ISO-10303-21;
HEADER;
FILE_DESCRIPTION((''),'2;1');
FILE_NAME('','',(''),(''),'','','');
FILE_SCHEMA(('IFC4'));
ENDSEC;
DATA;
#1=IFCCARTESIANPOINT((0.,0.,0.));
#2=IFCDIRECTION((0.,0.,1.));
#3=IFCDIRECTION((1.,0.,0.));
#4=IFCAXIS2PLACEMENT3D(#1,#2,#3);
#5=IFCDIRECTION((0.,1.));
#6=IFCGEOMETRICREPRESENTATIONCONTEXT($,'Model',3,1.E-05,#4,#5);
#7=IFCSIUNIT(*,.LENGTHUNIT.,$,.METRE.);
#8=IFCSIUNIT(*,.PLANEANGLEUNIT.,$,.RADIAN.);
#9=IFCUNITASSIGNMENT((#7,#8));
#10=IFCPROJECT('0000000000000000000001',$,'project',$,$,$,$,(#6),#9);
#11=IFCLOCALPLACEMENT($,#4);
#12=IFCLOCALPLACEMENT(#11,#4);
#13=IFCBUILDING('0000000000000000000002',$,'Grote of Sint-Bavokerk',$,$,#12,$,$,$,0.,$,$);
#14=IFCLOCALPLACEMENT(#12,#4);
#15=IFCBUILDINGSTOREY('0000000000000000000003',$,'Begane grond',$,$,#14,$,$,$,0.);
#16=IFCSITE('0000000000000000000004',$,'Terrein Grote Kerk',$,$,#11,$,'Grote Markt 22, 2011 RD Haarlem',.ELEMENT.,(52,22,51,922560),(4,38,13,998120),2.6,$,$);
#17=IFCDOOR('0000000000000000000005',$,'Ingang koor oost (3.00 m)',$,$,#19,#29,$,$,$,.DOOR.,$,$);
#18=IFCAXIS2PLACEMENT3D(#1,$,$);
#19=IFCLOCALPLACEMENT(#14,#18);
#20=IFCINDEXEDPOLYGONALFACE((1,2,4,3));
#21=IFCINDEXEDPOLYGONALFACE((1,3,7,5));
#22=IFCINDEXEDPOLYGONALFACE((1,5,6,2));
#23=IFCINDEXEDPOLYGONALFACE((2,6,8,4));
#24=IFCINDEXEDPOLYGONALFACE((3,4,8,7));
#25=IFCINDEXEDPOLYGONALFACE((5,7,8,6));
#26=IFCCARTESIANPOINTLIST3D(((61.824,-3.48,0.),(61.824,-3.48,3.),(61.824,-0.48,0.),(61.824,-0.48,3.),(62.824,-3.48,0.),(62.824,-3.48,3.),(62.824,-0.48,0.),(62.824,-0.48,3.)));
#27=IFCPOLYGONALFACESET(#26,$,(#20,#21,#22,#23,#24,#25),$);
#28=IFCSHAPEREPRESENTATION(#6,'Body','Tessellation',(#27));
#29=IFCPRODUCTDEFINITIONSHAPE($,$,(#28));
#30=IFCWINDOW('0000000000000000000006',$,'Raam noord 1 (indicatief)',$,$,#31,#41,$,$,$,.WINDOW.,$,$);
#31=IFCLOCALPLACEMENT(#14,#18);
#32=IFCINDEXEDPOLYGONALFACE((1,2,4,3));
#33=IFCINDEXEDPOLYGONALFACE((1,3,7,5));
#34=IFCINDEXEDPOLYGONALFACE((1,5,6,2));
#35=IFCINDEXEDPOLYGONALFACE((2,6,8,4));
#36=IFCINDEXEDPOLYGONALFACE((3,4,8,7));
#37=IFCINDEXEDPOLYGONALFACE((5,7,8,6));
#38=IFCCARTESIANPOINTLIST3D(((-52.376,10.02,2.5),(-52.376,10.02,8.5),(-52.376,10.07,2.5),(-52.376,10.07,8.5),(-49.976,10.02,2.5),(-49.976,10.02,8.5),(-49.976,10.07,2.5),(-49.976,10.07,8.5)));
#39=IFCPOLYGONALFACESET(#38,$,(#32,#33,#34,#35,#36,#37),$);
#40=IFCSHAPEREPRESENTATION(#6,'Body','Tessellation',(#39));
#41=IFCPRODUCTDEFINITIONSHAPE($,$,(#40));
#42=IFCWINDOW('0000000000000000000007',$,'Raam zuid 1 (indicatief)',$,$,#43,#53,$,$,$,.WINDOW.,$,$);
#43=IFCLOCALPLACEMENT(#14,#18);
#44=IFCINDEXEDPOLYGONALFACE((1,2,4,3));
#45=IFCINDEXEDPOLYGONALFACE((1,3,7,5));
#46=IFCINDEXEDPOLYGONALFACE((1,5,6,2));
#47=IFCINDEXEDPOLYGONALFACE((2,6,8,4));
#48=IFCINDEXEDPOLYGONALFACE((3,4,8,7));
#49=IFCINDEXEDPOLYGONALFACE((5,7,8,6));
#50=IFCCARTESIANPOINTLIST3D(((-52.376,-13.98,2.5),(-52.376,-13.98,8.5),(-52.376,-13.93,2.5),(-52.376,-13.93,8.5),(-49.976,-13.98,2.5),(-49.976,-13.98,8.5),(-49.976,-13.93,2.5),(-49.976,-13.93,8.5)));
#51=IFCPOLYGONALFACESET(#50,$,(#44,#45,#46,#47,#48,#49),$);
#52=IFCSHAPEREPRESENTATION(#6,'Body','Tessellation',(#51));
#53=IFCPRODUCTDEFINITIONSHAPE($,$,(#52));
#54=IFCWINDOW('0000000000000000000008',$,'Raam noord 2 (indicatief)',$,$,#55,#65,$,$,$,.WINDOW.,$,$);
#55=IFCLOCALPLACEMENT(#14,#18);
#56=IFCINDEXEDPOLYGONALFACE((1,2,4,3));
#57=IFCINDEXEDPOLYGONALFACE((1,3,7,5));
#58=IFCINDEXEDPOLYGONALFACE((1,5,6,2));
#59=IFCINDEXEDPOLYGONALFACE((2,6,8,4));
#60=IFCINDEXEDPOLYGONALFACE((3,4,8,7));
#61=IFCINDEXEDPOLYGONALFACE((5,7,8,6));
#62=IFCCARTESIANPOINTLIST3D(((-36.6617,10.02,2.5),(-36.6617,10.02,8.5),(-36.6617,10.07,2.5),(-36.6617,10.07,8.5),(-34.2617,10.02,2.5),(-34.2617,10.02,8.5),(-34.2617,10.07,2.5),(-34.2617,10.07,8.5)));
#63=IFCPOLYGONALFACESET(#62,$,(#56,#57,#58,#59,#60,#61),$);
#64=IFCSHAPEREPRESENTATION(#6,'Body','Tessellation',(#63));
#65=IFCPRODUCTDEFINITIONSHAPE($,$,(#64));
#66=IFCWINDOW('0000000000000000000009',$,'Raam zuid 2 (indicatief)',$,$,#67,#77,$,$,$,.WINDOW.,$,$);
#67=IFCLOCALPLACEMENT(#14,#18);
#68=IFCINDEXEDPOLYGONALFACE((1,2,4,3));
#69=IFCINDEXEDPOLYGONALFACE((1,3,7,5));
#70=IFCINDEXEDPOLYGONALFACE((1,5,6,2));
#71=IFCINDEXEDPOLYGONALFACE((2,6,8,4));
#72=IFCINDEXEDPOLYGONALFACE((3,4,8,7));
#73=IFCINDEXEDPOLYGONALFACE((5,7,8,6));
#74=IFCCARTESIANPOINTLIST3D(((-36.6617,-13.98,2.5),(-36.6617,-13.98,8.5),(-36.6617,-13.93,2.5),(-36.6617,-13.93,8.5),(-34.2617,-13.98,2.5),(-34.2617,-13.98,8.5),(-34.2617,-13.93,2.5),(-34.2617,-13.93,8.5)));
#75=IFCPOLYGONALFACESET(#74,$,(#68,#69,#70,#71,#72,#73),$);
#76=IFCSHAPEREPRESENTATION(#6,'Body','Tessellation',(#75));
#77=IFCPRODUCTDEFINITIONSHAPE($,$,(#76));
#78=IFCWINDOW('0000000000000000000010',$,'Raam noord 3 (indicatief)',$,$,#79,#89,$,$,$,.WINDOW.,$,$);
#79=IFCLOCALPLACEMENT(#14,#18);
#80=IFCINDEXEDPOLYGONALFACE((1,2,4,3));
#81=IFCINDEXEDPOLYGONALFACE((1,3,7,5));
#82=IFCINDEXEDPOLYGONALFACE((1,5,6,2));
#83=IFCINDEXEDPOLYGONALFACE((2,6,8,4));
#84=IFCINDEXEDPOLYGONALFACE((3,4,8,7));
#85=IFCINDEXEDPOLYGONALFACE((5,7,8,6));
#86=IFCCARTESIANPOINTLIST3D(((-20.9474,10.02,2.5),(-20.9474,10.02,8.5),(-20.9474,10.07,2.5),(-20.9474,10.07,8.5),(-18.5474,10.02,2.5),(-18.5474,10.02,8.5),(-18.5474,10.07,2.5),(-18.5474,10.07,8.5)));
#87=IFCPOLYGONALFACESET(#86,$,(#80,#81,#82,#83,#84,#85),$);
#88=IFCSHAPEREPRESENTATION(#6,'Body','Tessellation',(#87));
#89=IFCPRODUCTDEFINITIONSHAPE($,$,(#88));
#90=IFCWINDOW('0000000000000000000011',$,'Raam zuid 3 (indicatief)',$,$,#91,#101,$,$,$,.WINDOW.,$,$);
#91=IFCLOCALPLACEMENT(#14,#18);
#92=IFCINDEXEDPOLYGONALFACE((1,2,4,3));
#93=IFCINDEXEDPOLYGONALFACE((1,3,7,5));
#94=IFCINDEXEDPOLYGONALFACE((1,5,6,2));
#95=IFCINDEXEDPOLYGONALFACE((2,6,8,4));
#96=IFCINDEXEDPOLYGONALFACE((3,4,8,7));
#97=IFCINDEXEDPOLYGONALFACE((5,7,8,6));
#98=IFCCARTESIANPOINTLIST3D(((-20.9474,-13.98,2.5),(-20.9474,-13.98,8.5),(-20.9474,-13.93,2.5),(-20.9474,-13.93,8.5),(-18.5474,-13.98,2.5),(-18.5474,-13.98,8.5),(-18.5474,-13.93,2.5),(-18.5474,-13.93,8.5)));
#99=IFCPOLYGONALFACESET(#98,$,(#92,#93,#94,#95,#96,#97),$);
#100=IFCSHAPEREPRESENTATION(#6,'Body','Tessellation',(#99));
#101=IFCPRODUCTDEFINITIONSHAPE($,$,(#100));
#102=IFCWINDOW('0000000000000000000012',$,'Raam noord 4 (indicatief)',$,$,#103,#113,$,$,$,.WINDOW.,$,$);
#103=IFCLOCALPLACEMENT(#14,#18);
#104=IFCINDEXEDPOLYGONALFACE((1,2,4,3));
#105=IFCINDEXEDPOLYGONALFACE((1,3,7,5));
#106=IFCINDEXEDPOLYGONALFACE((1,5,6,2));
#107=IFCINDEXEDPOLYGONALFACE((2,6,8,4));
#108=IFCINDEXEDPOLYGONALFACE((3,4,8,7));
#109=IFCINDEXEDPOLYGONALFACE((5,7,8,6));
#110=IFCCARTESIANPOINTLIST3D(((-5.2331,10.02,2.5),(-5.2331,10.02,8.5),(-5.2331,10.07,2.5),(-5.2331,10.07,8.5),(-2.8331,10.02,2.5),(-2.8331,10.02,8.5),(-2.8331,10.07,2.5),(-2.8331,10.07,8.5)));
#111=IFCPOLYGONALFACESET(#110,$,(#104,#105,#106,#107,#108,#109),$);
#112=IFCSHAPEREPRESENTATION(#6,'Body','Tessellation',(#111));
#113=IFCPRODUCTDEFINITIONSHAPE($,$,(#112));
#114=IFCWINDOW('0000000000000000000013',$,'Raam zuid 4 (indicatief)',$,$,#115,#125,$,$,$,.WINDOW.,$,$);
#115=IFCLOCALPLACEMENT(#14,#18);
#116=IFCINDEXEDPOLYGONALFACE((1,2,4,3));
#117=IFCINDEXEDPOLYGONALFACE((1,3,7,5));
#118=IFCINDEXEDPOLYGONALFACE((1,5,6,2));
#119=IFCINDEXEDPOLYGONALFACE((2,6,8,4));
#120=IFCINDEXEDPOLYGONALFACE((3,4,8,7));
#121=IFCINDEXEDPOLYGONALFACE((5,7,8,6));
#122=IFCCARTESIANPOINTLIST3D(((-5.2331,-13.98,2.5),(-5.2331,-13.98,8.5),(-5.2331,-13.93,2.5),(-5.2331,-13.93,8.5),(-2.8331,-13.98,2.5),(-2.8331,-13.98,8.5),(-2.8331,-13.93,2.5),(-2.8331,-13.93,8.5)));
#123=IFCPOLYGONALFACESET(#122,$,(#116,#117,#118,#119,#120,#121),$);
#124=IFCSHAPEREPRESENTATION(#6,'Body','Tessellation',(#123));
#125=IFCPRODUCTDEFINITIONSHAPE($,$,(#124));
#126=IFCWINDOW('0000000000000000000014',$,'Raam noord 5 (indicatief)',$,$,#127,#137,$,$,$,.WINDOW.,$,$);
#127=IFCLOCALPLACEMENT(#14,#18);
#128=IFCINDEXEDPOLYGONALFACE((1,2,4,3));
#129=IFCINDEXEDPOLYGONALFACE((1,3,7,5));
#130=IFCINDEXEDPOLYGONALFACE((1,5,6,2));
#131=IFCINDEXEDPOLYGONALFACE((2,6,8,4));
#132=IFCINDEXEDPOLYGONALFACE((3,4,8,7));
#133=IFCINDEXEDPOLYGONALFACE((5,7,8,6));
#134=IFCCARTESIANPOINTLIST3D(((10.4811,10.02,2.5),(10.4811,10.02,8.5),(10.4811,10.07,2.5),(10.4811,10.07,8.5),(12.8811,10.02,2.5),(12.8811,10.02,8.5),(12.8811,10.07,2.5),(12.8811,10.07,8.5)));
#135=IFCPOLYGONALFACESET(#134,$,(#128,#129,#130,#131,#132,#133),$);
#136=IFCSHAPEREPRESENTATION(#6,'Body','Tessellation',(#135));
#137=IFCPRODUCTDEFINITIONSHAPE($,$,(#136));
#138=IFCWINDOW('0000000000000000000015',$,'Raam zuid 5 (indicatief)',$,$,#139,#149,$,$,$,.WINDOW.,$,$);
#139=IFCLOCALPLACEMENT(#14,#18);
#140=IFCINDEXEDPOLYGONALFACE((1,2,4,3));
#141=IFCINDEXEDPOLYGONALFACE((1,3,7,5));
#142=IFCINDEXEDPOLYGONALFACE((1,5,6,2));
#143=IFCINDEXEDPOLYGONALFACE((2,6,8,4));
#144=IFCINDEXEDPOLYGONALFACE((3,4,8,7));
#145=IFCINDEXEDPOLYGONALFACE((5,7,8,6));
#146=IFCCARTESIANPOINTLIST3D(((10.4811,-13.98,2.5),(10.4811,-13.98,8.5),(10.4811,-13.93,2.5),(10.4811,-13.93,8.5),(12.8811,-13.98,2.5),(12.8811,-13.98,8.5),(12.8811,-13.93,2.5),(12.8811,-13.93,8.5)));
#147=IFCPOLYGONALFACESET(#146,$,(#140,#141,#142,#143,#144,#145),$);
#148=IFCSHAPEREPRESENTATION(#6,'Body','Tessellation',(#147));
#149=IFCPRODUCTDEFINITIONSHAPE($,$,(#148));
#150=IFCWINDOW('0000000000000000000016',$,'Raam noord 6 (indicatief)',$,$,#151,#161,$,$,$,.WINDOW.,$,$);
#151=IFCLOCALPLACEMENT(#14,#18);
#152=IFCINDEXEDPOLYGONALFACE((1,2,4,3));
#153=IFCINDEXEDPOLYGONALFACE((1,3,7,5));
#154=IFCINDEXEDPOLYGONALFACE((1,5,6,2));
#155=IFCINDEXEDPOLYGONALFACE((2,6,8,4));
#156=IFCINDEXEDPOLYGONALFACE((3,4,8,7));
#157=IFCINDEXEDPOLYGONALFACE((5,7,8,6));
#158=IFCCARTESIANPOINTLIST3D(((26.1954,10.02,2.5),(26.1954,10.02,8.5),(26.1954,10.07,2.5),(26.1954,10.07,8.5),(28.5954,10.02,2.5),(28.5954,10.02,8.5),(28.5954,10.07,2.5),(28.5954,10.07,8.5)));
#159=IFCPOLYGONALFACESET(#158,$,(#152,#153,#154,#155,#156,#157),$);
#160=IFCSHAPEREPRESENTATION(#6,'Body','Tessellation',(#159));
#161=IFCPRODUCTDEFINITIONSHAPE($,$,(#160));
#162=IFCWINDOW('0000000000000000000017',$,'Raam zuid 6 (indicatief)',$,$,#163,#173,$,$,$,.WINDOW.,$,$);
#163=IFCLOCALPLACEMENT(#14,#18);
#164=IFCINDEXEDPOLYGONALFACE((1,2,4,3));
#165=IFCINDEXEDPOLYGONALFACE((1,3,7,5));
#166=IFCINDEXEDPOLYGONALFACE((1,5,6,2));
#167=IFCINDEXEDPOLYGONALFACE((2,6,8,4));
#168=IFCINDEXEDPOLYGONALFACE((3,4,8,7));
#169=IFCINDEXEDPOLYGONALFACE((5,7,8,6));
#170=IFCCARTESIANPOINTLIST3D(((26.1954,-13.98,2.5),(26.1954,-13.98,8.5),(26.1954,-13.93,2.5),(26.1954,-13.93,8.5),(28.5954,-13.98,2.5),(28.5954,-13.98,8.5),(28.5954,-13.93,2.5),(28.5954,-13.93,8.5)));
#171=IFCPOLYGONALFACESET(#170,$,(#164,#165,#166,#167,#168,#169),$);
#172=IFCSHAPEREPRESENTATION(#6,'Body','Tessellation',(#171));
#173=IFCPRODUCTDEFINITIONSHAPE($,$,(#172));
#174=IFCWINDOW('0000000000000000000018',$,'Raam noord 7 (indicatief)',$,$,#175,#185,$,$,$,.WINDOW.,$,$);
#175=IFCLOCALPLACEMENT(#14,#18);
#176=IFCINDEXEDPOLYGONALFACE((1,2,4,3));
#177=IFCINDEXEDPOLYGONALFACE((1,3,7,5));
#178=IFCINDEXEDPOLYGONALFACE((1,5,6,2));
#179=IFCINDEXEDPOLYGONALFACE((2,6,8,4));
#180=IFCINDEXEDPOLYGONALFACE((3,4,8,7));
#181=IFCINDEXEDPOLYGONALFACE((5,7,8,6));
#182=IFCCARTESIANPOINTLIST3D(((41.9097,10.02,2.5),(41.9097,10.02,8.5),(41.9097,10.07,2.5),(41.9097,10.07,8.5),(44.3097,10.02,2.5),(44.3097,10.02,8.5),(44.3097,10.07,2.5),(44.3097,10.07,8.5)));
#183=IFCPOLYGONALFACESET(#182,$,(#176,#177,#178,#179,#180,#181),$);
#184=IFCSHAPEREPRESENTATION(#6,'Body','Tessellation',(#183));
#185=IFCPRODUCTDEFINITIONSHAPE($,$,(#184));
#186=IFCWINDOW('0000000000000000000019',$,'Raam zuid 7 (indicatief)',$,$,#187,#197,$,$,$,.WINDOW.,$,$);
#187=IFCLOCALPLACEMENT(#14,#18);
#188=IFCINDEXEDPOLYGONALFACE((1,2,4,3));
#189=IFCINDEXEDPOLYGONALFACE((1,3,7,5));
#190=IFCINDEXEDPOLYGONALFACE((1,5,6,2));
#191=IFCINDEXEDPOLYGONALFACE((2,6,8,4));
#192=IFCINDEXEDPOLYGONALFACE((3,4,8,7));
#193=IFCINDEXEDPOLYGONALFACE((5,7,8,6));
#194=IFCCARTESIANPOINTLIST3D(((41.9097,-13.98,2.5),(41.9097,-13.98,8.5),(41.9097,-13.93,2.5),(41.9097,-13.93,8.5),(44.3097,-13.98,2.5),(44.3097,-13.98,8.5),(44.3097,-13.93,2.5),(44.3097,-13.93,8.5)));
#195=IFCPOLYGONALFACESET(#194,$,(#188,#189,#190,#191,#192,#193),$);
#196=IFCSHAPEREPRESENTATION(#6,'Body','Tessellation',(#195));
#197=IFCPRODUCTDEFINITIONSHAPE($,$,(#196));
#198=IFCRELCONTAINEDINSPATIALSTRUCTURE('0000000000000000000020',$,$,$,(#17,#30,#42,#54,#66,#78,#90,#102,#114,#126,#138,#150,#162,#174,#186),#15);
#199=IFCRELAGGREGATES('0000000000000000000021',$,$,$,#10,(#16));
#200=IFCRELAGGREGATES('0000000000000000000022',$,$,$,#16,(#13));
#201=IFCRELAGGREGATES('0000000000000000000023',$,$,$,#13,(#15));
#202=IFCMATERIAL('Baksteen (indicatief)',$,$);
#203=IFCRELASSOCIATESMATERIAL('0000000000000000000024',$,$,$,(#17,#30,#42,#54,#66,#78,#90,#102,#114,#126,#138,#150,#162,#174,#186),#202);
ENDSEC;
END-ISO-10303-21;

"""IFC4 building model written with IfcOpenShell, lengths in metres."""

from ifc_helpers import new_model, si_unit, direction, frame, origin_with_axes, place, context, project, spatial, indexed_curve, outline, extrude, material, element, save


model = new_model("IFC4")

# Units and contexts
model_context = context("Model", 3, precision=1e-05, world=origin_with_axes(), true_north=direction((0.0, 1.0)))
ifc_project = project(units=[si_unit("LENGTHUNIT", "METRE"), si_unit("PLANEANGLEUNIT", "RADIAN")], contexts=[model_context])

# Site, building, storey
site_placement = place(None, origin_with_axes())
site = spatial("IfcSite", under=ifc_project, at=site_placement, Name="Terrein Grote Kerk", LongName="Grote Markt 22, 2011 RD Haarlem", CompositionType="ELEMENT", RefLatitude=(52, 22, 51, 922560), RefLongitude=(4, 38, 13, 998120), RefElevation=2.6)
building_placement = place(site_placement, origin_with_axes())
building = spatial("IfcBuilding", under=site, at=building_placement, Name="Grote of Sint-Bavokerk", ElevationOfRefHeight=0.0)
storey_placement = place(building_placement, origin_with_axes())
storey = spatial("IfcBuildingStorey", under=building, at=storey_placement, Name="Begane grond", Elevation=0.0)

# Door
ifc_material = material(Name="Baksteen (indicatief)")
door_placement = place(storey_placement, origin_with_axes())
element("IfcDoor", 1, at=door_placement, inside=storey, material=ifc_material, Name="Ingang koor oost (3.00 m)", PredefinedType="DOOR", context=model_context, shape_type="SweptSolid", body=[
    extrude(outline(indexed_curve([(61.824, -3.48), (62.824, -3.48), (62.824, -0.48), (61.824, -0.48), (61.824, -3.48)])), origin_with_axes(), (0.0, 0.0, 1.0), 3.0),
])

# Windows
window_1_placement = place(storey_placement, origin_with_axes())
element("IfcWindow", 2, at=window_1_placement, inside=storey, material=ifc_material, Name="Raam noord 1 (indicatief)", PredefinedType="WINDOW", context=model_context, shape_type="SweptSolid", body=[
    extrude(outline(indexed_curve([(-52.376, 10.02), (-49.976, 10.02), (-49.976, 10.07), (-52.376, 10.07), (-52.376, 10.02)])), frame((0.0, 0.0, 2.5), z_axis=(0.0, 0.0, 1.0), x_axis=(1.0, 0.0, 0.0)), (0.0, 0.0, 1.0), 6.0),
])
window_2_placement = place(storey_placement, origin_with_axes())
element("IfcWindow", 3, at=window_2_placement, inside=storey, material=ifc_material, Name="Raam zuid 1 (indicatief)", PredefinedType="WINDOW", context=model_context, shape_type="SweptSolid", body=[
    extrude(outline(indexed_curve([(-52.376, -13.98), (-49.976, -13.98), (-49.976, -13.93), (-52.376, -13.93), (-52.376, -13.98)])), frame((0.0, 0.0, 2.5), z_axis=(0.0, 0.0, 1.0), x_axis=(1.0, 0.0, 0.0)), (0.0, 0.0, 1.0), 6.0),
])
window_3_placement = place(storey_placement, origin_with_axes())
element("IfcWindow", 4, at=window_3_placement, inside=storey, material=ifc_material, Name="Raam noord 2 (indicatief)", PredefinedType="WINDOW", context=model_context, shape_type="SweptSolid", body=[
    extrude(outline(indexed_curve([(-36.6617, 10.02), (-34.2617, 10.02), (-34.2617, 10.07), (-36.6617, 10.07), (-36.6617, 10.02)])), frame((0.0, 0.0, 2.5), z_axis=(0.0, 0.0, 1.0), x_axis=(1.0, 0.0, 0.0)), (0.0, 0.0, 1.0), 6.0),
])
window_4_placement = place(storey_placement, origin_with_axes())
element("IfcWindow", 5, at=window_4_placement, inside=storey, material=ifc_material, Name="Raam zuid 2 (indicatief)", PredefinedType="WINDOW", context=model_context, shape_type="SweptSolid", body=[
    extrude(outline(indexed_curve([(-36.6617, -13.98), (-34.2617, -13.98), (-34.2617, -13.93), (-36.6617, -13.93), (-36.6617, -13.98)])), frame((0.0, 0.0, 2.5), z_axis=(0.0, 0.0, 1.0), x_axis=(1.0, 0.0, 0.0)), (0.0, 0.0, 1.0), 6.0),
])
window_5_placement = place(storey_placement, origin_with_axes())
element("IfcWindow", 6, at=window_5_placement, inside=storey, material=ifc_material, Name="Raam noord 3 (indicatief)", PredefinedType="WINDOW", context=model_context, shape_type="SweptSolid", body=[
    extrude(outline(indexed_curve([(-20.9474, 10.02), (-18.5474, 10.02), (-18.5474, 10.07), (-20.9474, 10.07), (-20.9474, 10.02)])), frame((0.0, 0.0, 2.5), z_axis=(0.0, 0.0, 1.0), x_axis=(1.0, 0.0, 0.0)), (0.0, 0.0, 1.0), 6.0),
])
window_6_placement = place(storey_placement, origin_with_axes())
element("IfcWindow", 7, at=window_6_placement, inside=storey, material=ifc_material, Name="Raam zuid 3 (indicatief)", PredefinedType="WINDOW", context=model_context, shape_type="SweptSolid", body=[
    extrude(outline(indexed_curve([(-20.9474, -13.98), (-18.5474, -13.98), (-18.5474, -13.93), (-20.9474, -13.93), (-20.9474, -13.98)])), frame((0.0, 0.0, 2.5), z_axis=(0.0, 0.0, 1.0), x_axis=(1.0, 0.0, 0.0)), (0.0, 0.0, 1.0), 6.0),
])
window_7_placement = place(storey_placement, origin_with_axes())
element("IfcWindow", 8, at=window_7_placement, inside=storey, material=ifc_material, Name="Raam noord 4 (indicatief)", PredefinedType="WINDOW", context=model_context, shape_type="SweptSolid", body=[
    extrude(outline(indexed_curve([(-5.2331, 10.02), (-2.8331, 10.02), (-2.8331, 10.07), (-5.2331, 10.07), (-5.2331, 10.02)])), frame((0.0, 0.0, 2.5), z_axis=(0.0, 0.0, 1.0), x_axis=(1.0, 0.0, 0.0)), (0.0, 0.0, 1.0), 6.0),
])
window_8_placement = place(storey_placement, origin_with_axes())
element("IfcWindow", 9, at=window_8_placement, inside=storey, material=ifc_material, Name="Raam zuid 4 (indicatief)", PredefinedType="WINDOW", context=model_context, shape_type="SweptSolid", body=[
    extrude(outline(indexed_curve([(-5.2331, -13.98), (-2.8331, -13.98), (-2.8331, -13.93), (-5.2331, -13.93), (-5.2331, -13.98)])), frame((0.0, 0.0, 2.5), z_axis=(0.0, 0.0, 1.0), x_axis=(1.0, 0.0, 0.0)), (0.0, 0.0, 1.0), 6.0),
])
window_9_placement = place(storey_placement, origin_with_axes())
element("IfcWindow", 10, at=window_9_placement, inside=storey, material=ifc_material, Name="Raam noord 5 (indicatief)", PredefinedType="WINDOW", context=model_context, shape_type="SweptSolid", body=[
    extrude(outline(indexed_curve([(10.4811, 10.02), (12.8811, 10.02), (12.8811, 10.07), (10.4811, 10.07), (10.4811, 10.02)])), frame((0.0, 0.0, 2.5), z_axis=(0.0, 0.0, 1.0), x_axis=(1.0, 0.0, 0.0)), (0.0, 0.0, 1.0), 6.0),
])
window_10_placement = place(storey_placement, origin_with_axes())
element("IfcWindow", 11, at=window_10_placement, inside=storey, material=ifc_material, Name="Raam zuid 5 (indicatief)", PredefinedType="WINDOW", context=model_context, shape_type="SweptSolid", body=[
    extrude(outline(indexed_curve([(10.4811, -13.98), (12.8811, -13.98), (12.8811, -13.93), (10.4811, -13.93), (10.4811, -13.98)])), frame((0.0, 0.0, 2.5), z_axis=(0.0, 0.0, 1.0), x_axis=(1.0, 0.0, 0.0)), (0.0, 0.0, 1.0), 6.0),
])
window_11_placement = place(storey_placement, origin_with_axes())
element("IfcWindow", 12, at=window_11_placement, inside=storey, material=ifc_material, Name="Raam noord 6 (indicatief)", PredefinedType="WINDOW", context=model_context, shape_type="SweptSolid", body=[
    extrude(outline(indexed_curve([(26.1954, 10.02), (28.5954, 10.02), (28.5954, 10.07), (26.1954, 10.07), (26.1954, 10.02)])), frame((0.0, 0.0, 2.5), z_axis=(0.0, 0.0, 1.0), x_axis=(1.0, 0.0, 0.0)), (0.0, 0.0, 1.0), 6.0),
])
window_12_placement = place(storey_placement, origin_with_axes())
element("IfcWindow", 13, at=window_12_placement, inside=storey, material=ifc_material, Name="Raam zuid 6 (indicatief)", PredefinedType="WINDOW", context=model_context, shape_type="SweptSolid", body=[
    extrude(outline(indexed_curve([(26.1954, -13.98), (28.5954, -13.98), (28.5954, -13.93), (26.1954, -13.93), (26.1954, -13.98)])), frame((0.0, 0.0, 2.5), z_axis=(0.0, 0.0, 1.0), x_axis=(1.0, 0.0, 0.0)), (0.0, 0.0, 1.0), 6.0),
])
window_13_placement = place(storey_placement, origin_with_axes())
element("IfcWindow", 14, at=window_13_placement, inside=storey, material=ifc_material, Name="Raam noord 7 (indicatief)", PredefinedType="WINDOW", context=model_context, shape_type="SweptSolid", body=[
    extrude(outline(indexed_curve([(41.9097, 10.02), (44.3097, 10.02), (44.3097, 10.07), (41.9097, 10.07), (41.9097, 10.02)])), frame((0.0, 0.0, 2.5), z_axis=(0.0, 0.0, 1.0), x_axis=(1.0, 0.0, 0.0)), (0.0, 0.0, 1.0), 6.0),
])
window_14_placement = place(storey_placement, origin_with_axes())
element("IfcWindow", 15, at=window_14_placement, inside=storey, material=ifc_material, Name="Raam zuid 7 (indicatief)", PredefinedType="WINDOW", context=model_context, shape_type="SweptSolid", body=[
    extrude(outline(indexed_curve([(41.9097, -13.98), (44.3097, -13.98), (44.3097, -13.93), (41.9097, -13.93), (41.9097, -13.98)])), frame((0.0, 0.0, 2.5), z_axis=(0.0, 0.0, 1.0), x_axis=(1.0, 0.0, 0.0)), (0.0, 0.0, 1.0), 6.0),
])

save(model, "model.ifc")
